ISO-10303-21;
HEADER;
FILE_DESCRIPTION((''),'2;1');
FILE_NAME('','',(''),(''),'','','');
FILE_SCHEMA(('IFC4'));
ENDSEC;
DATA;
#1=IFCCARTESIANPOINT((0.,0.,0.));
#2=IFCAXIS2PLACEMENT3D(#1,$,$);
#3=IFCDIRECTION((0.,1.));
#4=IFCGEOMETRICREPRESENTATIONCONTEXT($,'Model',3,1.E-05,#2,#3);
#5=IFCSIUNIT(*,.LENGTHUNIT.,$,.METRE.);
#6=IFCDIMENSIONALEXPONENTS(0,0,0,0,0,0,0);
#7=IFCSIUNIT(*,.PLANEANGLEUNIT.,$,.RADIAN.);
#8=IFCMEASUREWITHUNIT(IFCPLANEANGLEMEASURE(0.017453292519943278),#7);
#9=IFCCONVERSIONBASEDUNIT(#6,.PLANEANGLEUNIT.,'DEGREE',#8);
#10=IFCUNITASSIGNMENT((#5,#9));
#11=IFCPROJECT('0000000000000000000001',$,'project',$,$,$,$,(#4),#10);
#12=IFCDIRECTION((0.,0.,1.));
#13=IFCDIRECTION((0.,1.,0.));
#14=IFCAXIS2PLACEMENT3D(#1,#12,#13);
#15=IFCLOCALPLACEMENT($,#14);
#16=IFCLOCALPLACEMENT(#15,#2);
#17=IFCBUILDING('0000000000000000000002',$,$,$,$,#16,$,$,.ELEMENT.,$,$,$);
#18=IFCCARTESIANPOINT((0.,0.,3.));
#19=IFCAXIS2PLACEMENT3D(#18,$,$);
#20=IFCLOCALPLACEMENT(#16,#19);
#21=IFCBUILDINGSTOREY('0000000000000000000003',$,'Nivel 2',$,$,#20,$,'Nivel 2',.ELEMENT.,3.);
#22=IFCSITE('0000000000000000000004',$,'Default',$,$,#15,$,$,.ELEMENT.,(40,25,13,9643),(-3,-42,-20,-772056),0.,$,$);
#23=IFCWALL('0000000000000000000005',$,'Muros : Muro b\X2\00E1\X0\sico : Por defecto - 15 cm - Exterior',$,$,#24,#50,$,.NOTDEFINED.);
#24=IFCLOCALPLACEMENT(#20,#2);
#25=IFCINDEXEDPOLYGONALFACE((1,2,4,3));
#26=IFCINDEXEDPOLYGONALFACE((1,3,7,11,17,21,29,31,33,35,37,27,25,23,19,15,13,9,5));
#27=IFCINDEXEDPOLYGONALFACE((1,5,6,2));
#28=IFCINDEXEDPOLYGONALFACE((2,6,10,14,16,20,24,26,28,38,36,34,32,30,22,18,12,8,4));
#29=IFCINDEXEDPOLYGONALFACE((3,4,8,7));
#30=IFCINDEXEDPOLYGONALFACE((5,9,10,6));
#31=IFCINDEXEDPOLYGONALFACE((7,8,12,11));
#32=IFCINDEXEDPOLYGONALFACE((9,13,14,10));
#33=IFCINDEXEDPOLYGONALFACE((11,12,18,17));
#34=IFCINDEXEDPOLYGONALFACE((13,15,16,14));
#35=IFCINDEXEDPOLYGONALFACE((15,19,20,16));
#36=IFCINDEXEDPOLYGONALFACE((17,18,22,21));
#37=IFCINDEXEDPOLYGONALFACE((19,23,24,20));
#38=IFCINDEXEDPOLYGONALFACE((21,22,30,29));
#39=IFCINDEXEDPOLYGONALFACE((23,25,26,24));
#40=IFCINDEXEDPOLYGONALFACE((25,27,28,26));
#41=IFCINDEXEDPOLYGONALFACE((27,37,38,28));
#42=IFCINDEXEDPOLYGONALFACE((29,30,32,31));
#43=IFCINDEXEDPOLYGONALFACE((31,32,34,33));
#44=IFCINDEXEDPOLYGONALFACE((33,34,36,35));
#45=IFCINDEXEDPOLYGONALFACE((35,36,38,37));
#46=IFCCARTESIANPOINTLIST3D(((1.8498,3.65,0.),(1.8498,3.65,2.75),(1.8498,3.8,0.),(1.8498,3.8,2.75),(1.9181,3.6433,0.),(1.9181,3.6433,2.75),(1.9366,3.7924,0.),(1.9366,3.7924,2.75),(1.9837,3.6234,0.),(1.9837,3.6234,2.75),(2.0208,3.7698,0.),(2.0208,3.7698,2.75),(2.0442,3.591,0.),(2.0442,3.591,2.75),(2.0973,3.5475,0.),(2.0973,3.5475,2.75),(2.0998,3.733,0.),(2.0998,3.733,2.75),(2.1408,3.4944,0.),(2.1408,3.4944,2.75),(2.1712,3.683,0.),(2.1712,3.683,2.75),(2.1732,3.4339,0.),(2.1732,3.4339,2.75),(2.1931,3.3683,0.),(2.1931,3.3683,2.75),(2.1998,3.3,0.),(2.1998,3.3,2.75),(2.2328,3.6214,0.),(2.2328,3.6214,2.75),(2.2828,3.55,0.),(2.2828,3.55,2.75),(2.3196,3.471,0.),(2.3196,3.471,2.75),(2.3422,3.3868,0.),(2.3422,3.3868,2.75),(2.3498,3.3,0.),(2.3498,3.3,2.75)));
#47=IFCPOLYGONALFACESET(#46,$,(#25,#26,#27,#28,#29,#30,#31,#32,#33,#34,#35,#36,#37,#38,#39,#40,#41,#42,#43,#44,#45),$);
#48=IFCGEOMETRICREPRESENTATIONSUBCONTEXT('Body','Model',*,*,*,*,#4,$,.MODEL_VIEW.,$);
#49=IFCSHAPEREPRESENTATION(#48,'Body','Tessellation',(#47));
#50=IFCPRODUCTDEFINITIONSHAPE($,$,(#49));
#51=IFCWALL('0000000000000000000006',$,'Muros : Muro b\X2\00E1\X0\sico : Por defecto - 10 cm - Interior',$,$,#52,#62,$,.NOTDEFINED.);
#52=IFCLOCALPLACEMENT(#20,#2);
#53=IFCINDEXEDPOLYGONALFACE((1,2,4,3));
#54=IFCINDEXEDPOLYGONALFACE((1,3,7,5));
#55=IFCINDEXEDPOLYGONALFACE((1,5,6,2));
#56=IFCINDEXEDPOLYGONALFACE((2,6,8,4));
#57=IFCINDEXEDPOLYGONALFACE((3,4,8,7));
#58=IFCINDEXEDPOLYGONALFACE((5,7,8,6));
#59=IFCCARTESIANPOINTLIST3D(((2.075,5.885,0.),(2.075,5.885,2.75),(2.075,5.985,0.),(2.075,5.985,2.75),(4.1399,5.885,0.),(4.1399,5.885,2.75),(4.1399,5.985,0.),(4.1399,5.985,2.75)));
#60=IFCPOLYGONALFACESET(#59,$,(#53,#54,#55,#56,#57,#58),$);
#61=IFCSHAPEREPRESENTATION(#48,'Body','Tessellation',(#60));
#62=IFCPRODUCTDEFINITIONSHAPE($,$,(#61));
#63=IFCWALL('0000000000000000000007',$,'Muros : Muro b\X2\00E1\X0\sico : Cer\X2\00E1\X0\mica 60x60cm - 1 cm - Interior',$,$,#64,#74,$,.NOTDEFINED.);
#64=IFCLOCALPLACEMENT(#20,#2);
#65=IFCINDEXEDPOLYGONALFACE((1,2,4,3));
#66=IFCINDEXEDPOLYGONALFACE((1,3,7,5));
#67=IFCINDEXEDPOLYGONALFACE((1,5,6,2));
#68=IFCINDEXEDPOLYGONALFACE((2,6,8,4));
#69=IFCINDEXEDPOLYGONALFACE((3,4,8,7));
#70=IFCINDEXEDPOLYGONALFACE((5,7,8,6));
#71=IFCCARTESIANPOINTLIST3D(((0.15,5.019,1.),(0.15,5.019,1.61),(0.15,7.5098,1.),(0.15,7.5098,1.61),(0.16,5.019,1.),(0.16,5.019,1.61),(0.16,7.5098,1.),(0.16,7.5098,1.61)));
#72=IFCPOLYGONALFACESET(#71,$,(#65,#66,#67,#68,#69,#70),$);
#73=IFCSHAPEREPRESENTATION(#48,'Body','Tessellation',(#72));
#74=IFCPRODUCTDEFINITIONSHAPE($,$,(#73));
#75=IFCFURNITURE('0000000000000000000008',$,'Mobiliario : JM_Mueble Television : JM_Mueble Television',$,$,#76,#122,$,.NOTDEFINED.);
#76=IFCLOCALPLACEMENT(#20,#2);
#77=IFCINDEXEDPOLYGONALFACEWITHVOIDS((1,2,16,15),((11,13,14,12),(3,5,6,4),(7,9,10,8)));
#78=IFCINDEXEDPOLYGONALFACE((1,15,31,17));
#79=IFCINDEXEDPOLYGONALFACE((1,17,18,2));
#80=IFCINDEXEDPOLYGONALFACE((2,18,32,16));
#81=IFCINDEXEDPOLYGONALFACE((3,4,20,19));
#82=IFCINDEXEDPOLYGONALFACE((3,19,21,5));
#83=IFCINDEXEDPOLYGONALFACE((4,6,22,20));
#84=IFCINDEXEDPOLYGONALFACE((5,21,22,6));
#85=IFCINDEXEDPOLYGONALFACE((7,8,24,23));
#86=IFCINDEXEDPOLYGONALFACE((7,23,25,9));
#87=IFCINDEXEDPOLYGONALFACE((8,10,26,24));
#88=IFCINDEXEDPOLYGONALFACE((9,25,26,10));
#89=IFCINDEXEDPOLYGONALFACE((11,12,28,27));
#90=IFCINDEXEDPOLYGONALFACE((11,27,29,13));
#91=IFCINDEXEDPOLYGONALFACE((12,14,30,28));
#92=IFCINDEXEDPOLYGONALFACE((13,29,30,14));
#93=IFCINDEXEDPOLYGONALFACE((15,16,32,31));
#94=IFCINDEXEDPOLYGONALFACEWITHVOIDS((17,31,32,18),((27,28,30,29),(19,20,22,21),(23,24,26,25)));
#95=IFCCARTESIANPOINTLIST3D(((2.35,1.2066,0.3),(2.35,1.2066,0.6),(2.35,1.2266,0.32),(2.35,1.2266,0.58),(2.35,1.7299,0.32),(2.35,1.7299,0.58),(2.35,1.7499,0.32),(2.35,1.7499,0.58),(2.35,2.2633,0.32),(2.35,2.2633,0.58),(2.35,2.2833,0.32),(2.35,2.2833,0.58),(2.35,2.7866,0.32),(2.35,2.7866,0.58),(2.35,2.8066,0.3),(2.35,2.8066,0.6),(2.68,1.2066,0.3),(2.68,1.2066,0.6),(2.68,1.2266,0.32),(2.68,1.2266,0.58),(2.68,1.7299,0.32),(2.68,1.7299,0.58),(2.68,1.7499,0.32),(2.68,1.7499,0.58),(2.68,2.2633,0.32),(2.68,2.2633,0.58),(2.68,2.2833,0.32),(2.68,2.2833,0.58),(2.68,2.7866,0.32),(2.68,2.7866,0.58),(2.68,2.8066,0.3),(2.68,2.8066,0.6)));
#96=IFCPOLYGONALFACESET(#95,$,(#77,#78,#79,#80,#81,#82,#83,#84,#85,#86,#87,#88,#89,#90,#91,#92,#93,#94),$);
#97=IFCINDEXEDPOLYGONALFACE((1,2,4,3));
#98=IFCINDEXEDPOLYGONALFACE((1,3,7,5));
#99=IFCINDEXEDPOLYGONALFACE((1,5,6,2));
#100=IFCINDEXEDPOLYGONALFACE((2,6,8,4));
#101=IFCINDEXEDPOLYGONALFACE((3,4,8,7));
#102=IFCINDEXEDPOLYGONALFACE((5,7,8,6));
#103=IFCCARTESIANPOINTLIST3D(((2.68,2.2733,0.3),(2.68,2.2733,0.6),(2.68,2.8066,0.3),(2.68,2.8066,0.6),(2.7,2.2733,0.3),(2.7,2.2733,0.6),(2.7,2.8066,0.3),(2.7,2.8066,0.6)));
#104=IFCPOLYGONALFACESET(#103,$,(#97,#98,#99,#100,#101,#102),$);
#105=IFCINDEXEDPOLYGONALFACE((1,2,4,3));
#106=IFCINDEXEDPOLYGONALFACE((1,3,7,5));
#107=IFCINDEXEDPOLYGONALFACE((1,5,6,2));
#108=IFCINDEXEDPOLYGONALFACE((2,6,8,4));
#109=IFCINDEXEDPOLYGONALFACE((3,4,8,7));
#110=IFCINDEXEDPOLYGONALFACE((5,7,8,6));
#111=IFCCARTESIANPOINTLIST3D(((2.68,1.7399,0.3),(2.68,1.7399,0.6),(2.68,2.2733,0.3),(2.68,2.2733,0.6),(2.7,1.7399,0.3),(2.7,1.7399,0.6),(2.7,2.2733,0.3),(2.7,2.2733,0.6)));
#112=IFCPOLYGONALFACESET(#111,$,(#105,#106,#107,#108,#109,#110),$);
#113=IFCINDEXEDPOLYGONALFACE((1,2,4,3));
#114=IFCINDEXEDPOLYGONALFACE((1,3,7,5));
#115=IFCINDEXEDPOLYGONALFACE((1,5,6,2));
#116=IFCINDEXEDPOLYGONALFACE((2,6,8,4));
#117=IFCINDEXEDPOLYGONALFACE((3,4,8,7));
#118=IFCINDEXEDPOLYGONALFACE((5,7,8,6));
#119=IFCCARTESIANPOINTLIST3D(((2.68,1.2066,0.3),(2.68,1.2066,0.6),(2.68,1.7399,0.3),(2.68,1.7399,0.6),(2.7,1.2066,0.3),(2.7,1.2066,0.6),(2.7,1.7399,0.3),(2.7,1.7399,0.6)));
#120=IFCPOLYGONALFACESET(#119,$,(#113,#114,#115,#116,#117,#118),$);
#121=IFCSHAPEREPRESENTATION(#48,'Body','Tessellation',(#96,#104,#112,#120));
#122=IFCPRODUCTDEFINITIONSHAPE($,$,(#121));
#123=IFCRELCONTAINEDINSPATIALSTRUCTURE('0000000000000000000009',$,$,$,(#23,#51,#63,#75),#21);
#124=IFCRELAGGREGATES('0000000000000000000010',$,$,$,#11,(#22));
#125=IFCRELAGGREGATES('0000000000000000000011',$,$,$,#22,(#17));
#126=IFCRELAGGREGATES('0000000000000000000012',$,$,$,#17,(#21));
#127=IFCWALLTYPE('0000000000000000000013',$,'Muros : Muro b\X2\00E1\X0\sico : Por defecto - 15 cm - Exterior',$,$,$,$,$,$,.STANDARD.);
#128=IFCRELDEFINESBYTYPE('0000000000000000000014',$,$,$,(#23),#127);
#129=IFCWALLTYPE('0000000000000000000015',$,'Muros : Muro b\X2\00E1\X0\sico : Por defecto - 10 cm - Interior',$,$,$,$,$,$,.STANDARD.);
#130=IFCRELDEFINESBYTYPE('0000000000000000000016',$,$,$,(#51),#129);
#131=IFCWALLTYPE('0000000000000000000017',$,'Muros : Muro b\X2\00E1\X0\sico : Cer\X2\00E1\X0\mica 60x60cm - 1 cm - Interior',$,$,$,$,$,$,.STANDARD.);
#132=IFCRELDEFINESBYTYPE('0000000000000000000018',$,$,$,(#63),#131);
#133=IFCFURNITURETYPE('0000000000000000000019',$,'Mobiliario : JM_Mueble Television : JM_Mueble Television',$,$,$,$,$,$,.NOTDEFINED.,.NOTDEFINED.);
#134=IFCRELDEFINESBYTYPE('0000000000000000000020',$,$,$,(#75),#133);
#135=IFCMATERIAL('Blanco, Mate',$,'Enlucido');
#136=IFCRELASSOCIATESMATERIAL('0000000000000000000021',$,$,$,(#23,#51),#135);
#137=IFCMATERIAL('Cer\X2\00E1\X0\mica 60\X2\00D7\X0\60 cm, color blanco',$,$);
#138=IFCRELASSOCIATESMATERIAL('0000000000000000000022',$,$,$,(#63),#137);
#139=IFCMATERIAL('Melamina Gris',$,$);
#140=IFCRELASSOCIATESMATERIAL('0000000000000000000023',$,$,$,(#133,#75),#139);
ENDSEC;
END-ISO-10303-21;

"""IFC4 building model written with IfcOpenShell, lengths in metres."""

from ifc_helpers import new_model, entity, si_unit, converted_unit, direction, frame, origin, place, context, subcontext, project, spatial, line, arc, indexed_curve, outline, extrude, source, transform, mapped, material, type_object, type_shapes, element, save


model = new_model("IFC4")

# Units and contexts
model_context = context("Model", 3, precision=1e-05, world=origin(), true_north=direction((0.0, 1.0)))
body_context = subcontext(model_context, "Body", "Model", "MODEL_VIEW")
ifc_project = project(units=[si_unit("LENGTHUNIT", "METRE"), converted_unit("PLANEANGLEUNIT", "DEGREE", entity("IfcPlaneAngleMeasure", 0.017453292519943278), si_unit("PLANEANGLEUNIT", "RADIAN"), dimensions=[0, 0, 0, 0, 0, 0, 0])], contexts=[model_context])

# Site, building, storey
site_placement = place(None, frame((0.0, 0.0, 0.0), z_axis=(0.0, 0.0, 1.0), x_axis=(0.0, 1.0, 0.0)))
site = spatial("IfcSite", under=ifc_project, at=site_placement, Name="Default", CompositionType="ELEMENT", RefLatitude=(40, 25, 13, 9643), RefLongitude=(-3, -42, -20, -772056), RefElevation=0.0)
building_placement = place(site_placement, origin())
building = spatial("IfcBuilding", under=site, at=building_placement, CompositionType="ELEMENT")
storey_placement = place(building_placement, frame((0.0, 0.0, 3.0)))
storey = spatial("IfcBuildingStorey", under=building, at=storey_placement, Name="Nivel 2", LongName="Nivel 2", CompositionType="ELEMENT", Elevation=3.0)

# Walls
ifc_material_1 = material(Name="Blanco, Mate", Category="Enlucido")
wall_type_1 = type_object("IfcWallType", Name="Muros : Muro básico : Por defecto - 15 cm - Exterior", PredefinedType="STANDARD")
wall_1_placement = place(storey_placement, frame((2.2748, 3.3, 0.0)))
element("IfcWall", 1, at=wall_1_placement, inside=storey, type_object=wall_type_1, material=ifc_material_1, Name="Muros : Muro básico : Por defecto - 15 cm - Exterior", PredefinedType="NOTDEFINED", context=body_context, shape_type="SweptSolid", body=[
    extrude(outline(indexed_curve([(-0.425, 0.35), (-0.1775, 0.2475), (-0.075, 0.0), (0.075, 0.0), (-0.0714, 0.3536), (-0.425, 0.5)], segments=[arc(1, 2, 3), line(3, 4), arc(4, 5, 6), line(6, 1)], self_intersect=False)), origin(), (0.0, 0.0, 1.0), 2.75),
])
wall_type_2 = type_object("IfcWallType", Name="Muros : Muro básico : Por defecto - 10 cm - Interior", PredefinedType="STANDARD")
wall_2_placement = place(storey_placement, frame((2.075, 5.935, 0.0)))
element("IfcWall", 2, at=wall_2_placement, inside=storey, type_object=wall_type_2, material=ifc_material_1, Name="Muros : Muro básico : Por defecto - 10 cm - Interior", PredefinedType="NOTDEFINED", context=body_context, shape_type="SweptSolid", body=[
    extrude(outline(indexed_curve([(2.0649, 0.05), (0.0, 0.05), (0.0, -0.05), (2.0649, -0.05), (2.0649, 0.05)], self_intersect=False)), origin(), (0.0, 0.0, 1.0), 2.75),
])
ifc_material_2 = material(Name="Cerámica 60×60 cm, color blanco")
wall_type_3 = type_object("IfcWallType", Name="Muros : Muro básico : Cerámica 60x60cm - 1 cm - Interior", PredefinedType="STANDARD")
wall_3_placement = place(storey_placement, frame((0.155, 5.019, 1.0), z_axis=(0.0, 0.0, 1.0), x_axis=(0.0, 1.0, 0.0)))
element("IfcWall", 3, at=wall_3_placement, inside=storey, type_object=wall_type_3, material=ifc_material_2, Name="Muros : Muro básico : Cerámica 60x60cm - 1 cm - Interior", PredefinedType="NOTDEFINED", context=body_context, shape_type="SweptSolid", body=[
    extrude(outline(indexed_curve([(2.4908, 0.005), (0.0, 0.005), (0.0, -0.005), (2.4908, -0.005), (2.4908, 0.005)], self_intersect=False)), origin(), (0.0, 0.0, 1.0), 0.61),
])

# Furniture
ifc_material_3 = material(Name="Melamina Gris")
furniture_type_1 = type_object("IfcFurnitureType", Name="Mobiliario : JM_Mueble Television : JM_Mueble Television", AssemblyPlace="NOTDEFINED", PredefinedType="NOTDEFINED", material=ifc_material_3)
shared_shape_1 = source(origin(), body_context, "Body", "SweptSolid", [
    extrude(outline(indexed_curve([(-0.15, -0.8), (0.15, -0.8), (0.15, 0.8), (-0.15, 0.8), (-0.15, -0.8)], self_intersect=False), holes=[indexed_curve([(0.13, -0.78), (-0.13, -0.78), (-0.13, -0.2767), (0.13, -0.2767), (0.13, -0.78)], self_intersect=False), indexed_curve([(0.13, 0.78), (0.13, 0.2767), (-0.13, 0.2767), (-0.13, 0.78), (0.13, 0.78)], self_intersect=False), indexed_curve([(-0.13, -0.2567), (-0.13, 0.2567), (0.13, 0.2567), (0.13, -0.2567), (-0.13, -0.2567)], self_intersect=False)]), frame((0.0, 0.0, 0.15), z_axis=(0.0, 1.0, 0.0), x_axis=(0.0, 0.0, -1.0)), (0.0, 0.0, 1.0), 0.33),
    extrude(outline(indexed_curve([(-0.01, -0.2667), (0.01, -0.2667), (0.01, 0.2667), (-0.01, 0.2667), (-0.01, -0.2667)], self_intersect=False)), frame((-0.5333, 0.34, 0.0), z_axis=(0.0, 0.0, 1.0), x_axis=(0.0, -1.0, 0.0)), (0.0, 0.0, 1.0), 0.3),
    extrude(outline(indexed_curve([(-0.01, -0.2667), (0.01, -0.2667), (0.01, 0.2667), (-0.01, 0.2667), (-0.01, -0.2667)], self_intersect=False)), frame((0.0, 0.34, 0.0), z_axis=(0.0, 0.0, 1.0), x_axis=(0.0, -1.0, 0.0)), (0.0, 0.0, 1.0), 0.3),
    extrude(outline(indexed_curve([(-0.01, -0.2667), (0.01, -0.2667), (0.01, 0.2667), (-0.01, 0.2667), (-0.01, -0.2667)], self_intersect=False)), frame((0.5333, 0.34, 0.0), z_axis=(0.0, 0.0, 1.0), x_axis=(0.0, -1.0, 0.0)), (0.0, 0.0, 1.0), 0.3),
])
type_shapes(furniture_type_1, [shared_shape_1])
furniture_1_placement = place(storey_placement, frame((2.35, 2.0066, 0.3), z_axis=(0.0, 0.0, 1.0), x_axis=(0.0, -1.0, 0.0)))
element("IfcFurniture", 4, at=furniture_1_placement, inside=storey, type_object=furniture_type_1, material=ifc_material_3, Name="Mobiliario : JM_Mueble Television : JM_Mueble Television", PredefinedType="NOTDEFINED", context=body_context, shape_type="MappedRepresentation", body=[
    mapped(shared_shape_1, transform((0.0, 0.0, 0.0), scale=1.0)),
])

save(model, "model.ifc")
